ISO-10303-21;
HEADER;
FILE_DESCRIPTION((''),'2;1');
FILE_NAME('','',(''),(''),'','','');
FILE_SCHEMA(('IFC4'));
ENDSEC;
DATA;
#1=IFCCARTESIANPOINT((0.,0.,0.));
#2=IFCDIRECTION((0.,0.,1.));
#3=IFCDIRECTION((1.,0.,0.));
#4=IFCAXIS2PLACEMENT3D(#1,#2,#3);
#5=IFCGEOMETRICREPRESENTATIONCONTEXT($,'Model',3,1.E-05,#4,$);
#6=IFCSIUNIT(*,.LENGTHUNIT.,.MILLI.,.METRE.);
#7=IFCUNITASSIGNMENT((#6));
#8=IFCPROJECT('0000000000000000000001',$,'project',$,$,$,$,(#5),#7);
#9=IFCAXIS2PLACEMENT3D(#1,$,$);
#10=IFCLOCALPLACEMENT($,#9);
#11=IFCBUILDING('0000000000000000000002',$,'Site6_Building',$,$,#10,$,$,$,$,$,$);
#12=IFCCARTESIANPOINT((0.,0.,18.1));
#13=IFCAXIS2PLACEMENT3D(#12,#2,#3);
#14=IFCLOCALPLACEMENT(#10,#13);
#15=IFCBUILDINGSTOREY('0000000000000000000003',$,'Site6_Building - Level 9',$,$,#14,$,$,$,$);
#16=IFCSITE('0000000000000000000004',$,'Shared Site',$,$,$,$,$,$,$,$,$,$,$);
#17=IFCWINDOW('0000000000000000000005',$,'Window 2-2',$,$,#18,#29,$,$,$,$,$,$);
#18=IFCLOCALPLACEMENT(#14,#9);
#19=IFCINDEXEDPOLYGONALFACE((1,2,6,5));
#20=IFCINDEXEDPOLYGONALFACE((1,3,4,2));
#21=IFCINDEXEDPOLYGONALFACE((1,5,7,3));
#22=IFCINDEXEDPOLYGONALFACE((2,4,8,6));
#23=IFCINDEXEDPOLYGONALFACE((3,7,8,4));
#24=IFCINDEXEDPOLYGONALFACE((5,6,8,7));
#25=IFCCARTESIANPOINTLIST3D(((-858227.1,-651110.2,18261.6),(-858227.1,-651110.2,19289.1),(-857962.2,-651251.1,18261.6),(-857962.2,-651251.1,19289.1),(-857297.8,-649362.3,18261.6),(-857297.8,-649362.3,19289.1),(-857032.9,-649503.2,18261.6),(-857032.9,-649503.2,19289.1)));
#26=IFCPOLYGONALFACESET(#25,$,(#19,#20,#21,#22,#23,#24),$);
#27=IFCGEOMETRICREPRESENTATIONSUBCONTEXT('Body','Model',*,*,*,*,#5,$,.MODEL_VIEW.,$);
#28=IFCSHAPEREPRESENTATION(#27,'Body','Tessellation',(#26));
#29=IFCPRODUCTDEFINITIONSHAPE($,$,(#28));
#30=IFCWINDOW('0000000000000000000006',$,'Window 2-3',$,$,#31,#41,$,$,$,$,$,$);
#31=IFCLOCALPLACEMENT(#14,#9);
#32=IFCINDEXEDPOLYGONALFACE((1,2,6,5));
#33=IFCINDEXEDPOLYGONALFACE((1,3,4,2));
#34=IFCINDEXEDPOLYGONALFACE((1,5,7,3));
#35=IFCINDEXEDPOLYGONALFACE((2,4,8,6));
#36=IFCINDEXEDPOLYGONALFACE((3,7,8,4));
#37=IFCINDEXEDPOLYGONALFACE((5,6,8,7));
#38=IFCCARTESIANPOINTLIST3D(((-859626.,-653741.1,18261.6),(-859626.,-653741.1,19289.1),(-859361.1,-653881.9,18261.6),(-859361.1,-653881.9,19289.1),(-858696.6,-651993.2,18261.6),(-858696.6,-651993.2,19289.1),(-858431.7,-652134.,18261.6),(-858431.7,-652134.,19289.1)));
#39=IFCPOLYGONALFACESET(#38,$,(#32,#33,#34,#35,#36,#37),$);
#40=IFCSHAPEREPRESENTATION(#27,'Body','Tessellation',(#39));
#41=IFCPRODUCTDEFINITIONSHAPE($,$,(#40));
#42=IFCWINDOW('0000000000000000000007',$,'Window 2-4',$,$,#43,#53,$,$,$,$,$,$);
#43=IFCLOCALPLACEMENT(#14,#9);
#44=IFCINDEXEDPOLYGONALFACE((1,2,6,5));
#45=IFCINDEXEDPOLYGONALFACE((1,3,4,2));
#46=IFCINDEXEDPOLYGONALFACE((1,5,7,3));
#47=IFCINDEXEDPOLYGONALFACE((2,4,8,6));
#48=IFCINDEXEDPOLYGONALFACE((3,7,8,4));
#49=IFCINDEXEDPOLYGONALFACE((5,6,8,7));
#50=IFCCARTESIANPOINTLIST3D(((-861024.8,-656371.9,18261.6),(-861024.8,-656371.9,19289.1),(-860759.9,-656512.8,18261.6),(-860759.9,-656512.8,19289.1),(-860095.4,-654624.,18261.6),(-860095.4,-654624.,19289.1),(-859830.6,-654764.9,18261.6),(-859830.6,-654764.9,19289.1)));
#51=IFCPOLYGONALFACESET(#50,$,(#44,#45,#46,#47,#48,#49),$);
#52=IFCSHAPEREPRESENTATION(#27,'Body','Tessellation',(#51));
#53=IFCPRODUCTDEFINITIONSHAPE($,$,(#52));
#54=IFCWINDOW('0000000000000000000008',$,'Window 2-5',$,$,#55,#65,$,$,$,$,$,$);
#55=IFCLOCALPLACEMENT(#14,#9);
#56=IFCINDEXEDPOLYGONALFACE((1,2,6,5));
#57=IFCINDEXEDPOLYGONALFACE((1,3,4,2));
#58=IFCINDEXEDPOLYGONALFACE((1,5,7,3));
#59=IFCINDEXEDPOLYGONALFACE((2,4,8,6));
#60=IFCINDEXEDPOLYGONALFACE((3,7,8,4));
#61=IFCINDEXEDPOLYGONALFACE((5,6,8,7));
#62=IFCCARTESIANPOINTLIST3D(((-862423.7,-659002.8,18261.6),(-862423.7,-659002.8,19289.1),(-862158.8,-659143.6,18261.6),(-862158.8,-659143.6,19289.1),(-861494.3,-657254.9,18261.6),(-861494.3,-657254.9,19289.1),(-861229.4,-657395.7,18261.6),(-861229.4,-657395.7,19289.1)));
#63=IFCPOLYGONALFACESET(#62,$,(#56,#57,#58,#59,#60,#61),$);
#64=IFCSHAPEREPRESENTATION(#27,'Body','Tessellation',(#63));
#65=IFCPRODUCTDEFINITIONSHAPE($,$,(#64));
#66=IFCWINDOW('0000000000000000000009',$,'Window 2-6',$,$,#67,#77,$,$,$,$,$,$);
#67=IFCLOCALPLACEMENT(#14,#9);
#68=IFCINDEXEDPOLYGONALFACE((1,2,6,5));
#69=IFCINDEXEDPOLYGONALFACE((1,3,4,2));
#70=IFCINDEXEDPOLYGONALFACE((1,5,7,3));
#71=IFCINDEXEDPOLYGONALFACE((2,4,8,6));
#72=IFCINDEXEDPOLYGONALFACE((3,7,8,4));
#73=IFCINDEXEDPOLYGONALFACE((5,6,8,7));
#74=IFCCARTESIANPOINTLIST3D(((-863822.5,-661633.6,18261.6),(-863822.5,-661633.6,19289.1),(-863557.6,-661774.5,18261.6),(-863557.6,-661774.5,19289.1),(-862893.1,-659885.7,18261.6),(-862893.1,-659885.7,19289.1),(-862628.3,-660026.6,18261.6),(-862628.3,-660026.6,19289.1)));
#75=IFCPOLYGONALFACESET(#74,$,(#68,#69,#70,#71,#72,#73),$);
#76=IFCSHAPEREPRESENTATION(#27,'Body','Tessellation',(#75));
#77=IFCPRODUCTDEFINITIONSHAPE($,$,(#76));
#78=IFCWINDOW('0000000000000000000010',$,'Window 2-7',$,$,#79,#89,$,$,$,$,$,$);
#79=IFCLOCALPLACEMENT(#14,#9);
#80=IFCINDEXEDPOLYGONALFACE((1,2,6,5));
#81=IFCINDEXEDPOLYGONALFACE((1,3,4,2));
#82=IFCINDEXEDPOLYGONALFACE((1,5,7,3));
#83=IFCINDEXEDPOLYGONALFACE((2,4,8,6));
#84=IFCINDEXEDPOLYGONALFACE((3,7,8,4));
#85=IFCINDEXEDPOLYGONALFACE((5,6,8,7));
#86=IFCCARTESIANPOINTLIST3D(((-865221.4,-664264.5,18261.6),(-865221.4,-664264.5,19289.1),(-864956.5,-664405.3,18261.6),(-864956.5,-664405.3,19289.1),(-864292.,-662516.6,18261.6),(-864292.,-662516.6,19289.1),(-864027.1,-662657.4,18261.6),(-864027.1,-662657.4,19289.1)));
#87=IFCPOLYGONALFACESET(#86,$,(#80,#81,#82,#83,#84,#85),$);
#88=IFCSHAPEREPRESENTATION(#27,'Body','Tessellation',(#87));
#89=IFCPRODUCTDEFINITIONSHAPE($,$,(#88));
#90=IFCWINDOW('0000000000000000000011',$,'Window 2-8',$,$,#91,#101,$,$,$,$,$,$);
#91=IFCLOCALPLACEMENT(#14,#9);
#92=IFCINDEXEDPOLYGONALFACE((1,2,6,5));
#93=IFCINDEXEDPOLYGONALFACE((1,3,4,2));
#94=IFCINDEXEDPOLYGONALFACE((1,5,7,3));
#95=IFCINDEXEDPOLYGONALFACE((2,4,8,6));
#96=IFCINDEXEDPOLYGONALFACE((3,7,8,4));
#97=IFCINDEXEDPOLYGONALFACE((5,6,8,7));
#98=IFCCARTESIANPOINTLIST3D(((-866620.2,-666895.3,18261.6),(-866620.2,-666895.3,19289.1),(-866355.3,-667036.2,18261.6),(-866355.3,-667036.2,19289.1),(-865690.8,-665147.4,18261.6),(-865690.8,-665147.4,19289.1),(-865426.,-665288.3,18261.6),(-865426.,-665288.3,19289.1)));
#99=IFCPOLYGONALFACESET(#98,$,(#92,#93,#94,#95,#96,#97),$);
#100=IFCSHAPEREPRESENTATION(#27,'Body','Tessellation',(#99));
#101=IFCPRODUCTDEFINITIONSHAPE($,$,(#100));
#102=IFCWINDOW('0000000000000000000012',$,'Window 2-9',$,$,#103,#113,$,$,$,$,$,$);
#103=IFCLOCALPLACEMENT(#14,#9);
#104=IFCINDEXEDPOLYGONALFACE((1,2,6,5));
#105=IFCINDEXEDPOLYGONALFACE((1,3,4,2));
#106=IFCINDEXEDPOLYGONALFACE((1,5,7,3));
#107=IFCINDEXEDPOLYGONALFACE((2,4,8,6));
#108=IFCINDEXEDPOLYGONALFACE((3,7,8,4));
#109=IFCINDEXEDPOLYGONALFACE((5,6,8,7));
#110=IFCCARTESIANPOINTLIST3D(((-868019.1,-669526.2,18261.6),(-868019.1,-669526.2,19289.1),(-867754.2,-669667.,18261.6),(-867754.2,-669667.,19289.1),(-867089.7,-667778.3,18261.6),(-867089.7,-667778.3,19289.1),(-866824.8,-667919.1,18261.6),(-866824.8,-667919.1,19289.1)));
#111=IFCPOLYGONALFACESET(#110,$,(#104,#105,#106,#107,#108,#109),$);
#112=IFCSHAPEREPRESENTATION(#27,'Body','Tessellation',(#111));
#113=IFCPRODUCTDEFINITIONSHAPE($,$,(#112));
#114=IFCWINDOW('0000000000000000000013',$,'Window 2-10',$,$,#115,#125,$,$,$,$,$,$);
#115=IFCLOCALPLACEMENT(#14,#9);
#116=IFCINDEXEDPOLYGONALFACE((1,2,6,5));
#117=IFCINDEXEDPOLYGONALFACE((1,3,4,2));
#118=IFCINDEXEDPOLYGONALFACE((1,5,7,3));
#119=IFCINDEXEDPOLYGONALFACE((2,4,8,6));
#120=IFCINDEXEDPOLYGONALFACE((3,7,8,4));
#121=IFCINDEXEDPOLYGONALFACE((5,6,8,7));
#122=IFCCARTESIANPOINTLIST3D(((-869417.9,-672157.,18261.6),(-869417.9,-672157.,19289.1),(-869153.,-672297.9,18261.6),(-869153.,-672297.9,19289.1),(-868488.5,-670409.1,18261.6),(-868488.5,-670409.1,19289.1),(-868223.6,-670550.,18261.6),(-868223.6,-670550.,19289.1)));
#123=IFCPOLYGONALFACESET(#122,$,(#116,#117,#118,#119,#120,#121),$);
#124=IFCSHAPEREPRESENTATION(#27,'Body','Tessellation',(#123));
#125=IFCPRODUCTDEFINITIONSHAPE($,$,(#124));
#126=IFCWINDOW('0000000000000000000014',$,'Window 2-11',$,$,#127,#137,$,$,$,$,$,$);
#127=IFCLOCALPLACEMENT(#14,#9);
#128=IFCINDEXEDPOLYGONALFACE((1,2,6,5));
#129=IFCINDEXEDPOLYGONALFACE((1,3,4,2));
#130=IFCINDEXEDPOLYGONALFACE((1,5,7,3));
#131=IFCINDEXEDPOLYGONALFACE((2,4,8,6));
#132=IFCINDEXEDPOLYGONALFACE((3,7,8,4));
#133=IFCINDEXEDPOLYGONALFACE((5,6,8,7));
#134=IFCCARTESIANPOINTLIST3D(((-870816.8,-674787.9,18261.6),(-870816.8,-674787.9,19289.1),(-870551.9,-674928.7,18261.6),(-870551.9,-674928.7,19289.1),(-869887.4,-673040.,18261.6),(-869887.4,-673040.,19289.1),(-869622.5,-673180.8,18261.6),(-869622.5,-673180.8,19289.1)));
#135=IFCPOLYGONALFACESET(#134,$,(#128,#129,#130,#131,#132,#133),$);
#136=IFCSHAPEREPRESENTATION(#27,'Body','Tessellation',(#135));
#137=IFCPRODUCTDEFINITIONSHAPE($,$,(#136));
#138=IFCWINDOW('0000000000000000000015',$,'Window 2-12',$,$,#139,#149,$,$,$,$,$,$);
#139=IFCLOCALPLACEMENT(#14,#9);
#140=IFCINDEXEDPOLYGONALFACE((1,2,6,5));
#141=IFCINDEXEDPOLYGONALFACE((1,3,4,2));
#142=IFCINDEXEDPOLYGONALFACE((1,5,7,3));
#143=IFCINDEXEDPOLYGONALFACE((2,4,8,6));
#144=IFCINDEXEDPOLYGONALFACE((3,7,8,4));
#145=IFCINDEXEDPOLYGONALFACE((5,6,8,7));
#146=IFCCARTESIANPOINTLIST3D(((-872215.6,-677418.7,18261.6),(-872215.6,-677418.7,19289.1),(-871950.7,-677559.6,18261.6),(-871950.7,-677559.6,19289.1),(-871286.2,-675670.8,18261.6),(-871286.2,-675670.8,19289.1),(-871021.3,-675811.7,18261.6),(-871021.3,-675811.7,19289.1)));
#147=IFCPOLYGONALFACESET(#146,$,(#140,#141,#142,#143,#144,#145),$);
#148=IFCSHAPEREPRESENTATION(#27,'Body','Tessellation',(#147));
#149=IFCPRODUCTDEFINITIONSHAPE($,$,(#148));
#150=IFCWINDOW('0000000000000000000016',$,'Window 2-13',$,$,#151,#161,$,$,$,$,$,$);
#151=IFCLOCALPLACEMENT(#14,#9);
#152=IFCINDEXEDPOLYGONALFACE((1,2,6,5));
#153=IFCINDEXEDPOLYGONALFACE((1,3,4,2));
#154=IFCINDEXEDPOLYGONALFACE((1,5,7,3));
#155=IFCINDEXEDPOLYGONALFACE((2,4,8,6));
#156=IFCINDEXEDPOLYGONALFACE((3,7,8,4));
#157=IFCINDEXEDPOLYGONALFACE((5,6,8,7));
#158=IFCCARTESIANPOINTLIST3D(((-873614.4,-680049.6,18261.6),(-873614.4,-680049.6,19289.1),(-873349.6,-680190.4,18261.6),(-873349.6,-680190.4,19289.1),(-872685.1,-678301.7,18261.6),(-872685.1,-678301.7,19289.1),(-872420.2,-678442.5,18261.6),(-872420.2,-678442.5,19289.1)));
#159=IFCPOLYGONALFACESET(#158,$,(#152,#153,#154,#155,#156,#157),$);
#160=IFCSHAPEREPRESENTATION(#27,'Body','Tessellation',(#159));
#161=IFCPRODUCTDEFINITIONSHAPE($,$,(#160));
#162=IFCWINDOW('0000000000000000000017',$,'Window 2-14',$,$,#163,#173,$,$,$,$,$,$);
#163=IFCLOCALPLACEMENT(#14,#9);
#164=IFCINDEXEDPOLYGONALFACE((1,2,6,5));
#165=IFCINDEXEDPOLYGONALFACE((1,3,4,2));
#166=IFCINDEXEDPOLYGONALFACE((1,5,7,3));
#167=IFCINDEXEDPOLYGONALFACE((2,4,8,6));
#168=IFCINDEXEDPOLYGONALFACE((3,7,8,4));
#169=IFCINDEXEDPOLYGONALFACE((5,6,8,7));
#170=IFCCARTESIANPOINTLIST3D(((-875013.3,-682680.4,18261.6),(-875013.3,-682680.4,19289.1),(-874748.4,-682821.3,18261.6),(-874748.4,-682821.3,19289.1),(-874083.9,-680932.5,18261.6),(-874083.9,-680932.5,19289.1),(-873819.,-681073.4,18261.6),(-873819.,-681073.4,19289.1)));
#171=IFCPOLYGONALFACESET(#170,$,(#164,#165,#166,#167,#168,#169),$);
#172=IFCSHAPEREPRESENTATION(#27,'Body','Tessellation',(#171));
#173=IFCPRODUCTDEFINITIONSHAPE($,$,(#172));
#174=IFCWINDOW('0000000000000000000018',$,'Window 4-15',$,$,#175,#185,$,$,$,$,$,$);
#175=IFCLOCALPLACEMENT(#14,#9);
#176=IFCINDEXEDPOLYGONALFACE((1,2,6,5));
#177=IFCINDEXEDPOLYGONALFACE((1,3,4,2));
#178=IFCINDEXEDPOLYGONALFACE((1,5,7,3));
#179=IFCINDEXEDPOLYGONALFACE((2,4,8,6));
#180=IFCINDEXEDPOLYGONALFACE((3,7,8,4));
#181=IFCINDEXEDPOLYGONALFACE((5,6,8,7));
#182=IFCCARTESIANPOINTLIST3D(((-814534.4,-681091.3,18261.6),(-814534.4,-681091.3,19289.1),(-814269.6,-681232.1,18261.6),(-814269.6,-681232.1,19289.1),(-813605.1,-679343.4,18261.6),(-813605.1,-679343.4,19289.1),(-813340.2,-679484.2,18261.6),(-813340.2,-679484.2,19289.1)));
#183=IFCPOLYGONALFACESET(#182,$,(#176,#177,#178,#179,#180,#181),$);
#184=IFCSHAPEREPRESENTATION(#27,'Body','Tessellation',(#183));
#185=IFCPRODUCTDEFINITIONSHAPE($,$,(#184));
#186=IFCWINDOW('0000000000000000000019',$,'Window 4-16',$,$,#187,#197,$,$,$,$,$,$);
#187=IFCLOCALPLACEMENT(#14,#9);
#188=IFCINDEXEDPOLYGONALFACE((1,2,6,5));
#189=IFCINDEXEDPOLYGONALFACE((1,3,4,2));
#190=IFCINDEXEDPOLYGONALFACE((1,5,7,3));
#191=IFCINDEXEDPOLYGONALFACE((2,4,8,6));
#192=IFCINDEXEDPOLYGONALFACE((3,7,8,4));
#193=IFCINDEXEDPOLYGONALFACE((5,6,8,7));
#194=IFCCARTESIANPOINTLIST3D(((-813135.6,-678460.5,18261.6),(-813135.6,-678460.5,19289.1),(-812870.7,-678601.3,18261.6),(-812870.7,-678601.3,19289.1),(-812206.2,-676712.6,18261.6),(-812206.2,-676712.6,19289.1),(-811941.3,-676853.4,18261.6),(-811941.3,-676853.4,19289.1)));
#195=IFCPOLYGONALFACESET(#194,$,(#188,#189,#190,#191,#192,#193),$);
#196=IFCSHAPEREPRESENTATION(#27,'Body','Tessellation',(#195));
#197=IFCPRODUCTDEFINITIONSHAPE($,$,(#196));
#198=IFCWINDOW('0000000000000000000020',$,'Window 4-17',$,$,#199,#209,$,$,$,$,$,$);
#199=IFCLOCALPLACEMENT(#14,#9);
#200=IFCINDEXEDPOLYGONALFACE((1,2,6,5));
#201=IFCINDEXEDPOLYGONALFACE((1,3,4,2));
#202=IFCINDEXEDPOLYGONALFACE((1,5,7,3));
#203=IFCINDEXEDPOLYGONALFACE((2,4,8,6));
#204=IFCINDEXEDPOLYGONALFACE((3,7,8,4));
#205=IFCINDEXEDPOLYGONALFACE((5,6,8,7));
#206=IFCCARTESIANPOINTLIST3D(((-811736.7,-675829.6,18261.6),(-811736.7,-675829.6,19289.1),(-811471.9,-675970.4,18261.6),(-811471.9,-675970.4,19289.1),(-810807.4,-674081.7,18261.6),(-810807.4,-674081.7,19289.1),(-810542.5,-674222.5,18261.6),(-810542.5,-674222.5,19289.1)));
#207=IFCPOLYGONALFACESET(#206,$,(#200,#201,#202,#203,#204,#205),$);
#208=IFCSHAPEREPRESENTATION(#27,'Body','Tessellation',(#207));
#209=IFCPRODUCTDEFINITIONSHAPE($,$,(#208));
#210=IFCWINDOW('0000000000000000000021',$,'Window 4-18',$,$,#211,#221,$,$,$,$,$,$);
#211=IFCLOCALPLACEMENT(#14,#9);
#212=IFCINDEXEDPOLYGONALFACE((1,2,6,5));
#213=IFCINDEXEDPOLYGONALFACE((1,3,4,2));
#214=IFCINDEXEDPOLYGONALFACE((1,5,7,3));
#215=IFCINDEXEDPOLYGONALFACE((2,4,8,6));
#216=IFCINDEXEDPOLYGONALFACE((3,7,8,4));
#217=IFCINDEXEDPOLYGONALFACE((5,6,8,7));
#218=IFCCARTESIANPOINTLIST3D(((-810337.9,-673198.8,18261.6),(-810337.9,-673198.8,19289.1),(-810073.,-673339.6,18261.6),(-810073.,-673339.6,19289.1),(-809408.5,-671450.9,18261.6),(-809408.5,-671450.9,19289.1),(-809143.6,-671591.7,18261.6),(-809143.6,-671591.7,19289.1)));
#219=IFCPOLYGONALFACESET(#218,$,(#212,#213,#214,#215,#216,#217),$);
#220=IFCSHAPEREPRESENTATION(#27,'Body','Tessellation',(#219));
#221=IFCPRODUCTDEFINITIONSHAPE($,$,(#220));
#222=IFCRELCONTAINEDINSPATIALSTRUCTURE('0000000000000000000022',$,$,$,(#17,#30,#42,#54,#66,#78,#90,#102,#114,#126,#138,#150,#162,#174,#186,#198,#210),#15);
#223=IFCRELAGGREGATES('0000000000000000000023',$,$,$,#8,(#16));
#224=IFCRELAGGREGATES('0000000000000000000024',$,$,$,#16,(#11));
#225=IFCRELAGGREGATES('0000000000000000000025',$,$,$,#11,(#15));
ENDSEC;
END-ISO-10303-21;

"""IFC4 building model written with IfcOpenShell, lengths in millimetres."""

from ifc_helpers import new_model, si_unit, frame, origin, origin_with_axes, place, context, subcontext, project, spatial, indexed_curve, outline, extrude, element, save


model = new_model("IFC4")

# Units and contexts
model_context = context("Model", 3, precision=1e-05, world=origin_with_axes())
body_context = subcontext(model_context, "Body", "Model", "MODEL_VIEW")
ifc_project = project(units=[si_unit("LENGTHUNIT", "METRE", prefix="MILLI")], contexts=[model_context])

# Site, building, storey
site = spatial("IfcSite", under=ifc_project, Name="Shared Site")
building_placement = place(None, origin())
building = spatial("IfcBuilding", under=site, at=building_placement, Name="Site6_Building")
storey_placement = place(building_placement, frame((0.0, 0.0, 18.1), z_axis=(0.0, 0.0, 1.0), x_axis=(1.0, 0.0, 0.0)))
storey = spatial("IfcBuildingStorey", under=building, at=storey_placement, Name="Site6_Building - Level 9")

# Windows
for number, where, z_axis, x_axis, name in (
    (1, (-857297.8, -649362.3, 18261.6), (0.0, 0.0, 1.0), (-0.469472, -0.882948, 0.0), "Window 2-2"),
    (2, (-858696.6, -651993.2, 18261.6), (0.0, 0.0, 1.0), (-0.469472, -0.882948, 0.0), "Window 2-3"),
    (3, (-860095.4, -654624.0, 18261.6), (0.0, 0.0, 1.0), (-0.469472, -0.882948, 0.0), "Window 2-4"),
    (4, (-861494.3, -657254.9, 18261.6), (0.0, 0.0, 1.0), (-0.469472, -0.882948, 0.0), "Window 2-5"),
    (5, (-862893.1, -659885.7, 18261.6), (0.0, 0.0, 1.0), (-0.469472, -0.882948, 0.0), "Window 2-6"),
    (6, (-864292.0, -662516.6, 18261.6), (0.0, 0.0, 1.0), (-0.469472, -0.882948, 0.0), "Window 2-7"),
    (7, (-865690.8, -665147.4, 18261.6), (0.0, 0.0, 1.0), (-0.469472, -0.882948, 0.0), "Window 2-8"),
    (8, (-867089.7, -667778.3, 18261.6), (0.0, 0.0, 1.0), (-0.469472, -0.882948, 0.0), "Window 2-9"),
    (9, (-868488.5, -670409.1, 18261.6), (0.0, 0.0, 1.0), (-0.469472, -0.882948, 0.0), "Window 2-10"),
    (10, (-869887.4, -673040.0, 18261.6), (0.0, 0.0, 1.0), (-0.469472, -0.882948, 0.0), "Window 2-11"),
    (11, (-871286.2, -675670.8, 18261.6), (0.0, 0.0, 1.0), (-0.469472, -0.882948, 0.0), "Window 2-12"),
    (12, (-872685.1, -678301.7, 18261.6), (0.0, 0.0, 1.0), (-0.469472, -0.882948, 0.0), "Window 2-13"),
    (13, (-874083.9, -680932.5, 18261.6), (0.0, 0.0, 1.0), (-0.469472, -0.882948, 0.0), "Window 2-14"),
    (14, (-814269.6, -681232.1, 18261.6), (0.0, 0.0, 1.0), (0.469472, 0.882948, 0.0), "Window 4-15"),
    (15, (-812870.7, -678601.3, 18261.6), (0.0, 0.0, 1.0), (0.469472, 0.882948, 0.0), "Window 4-16"),
    (16, (-811471.9, -675970.4, 18261.6), (0.0, 0.0, 1.0), (0.469472, 0.882948, 0.0), "Window 4-17"),
    (17, (-810073.0, -673339.6, 18261.6), (0.0, 0.0, 1.0), (0.469472, 0.882948, 0.0), "Window 4-18"),
):
    element("IfcWindow", number, at=place(storey_placement, frame(where, z_axis=z_axis, x_axis=x_axis)), inside=storey, Name=name, context=body_context, shape_type="SweptSolid", body=[
        extrude(outline(indexed_curve([(0.0, 0.0), (0.0, 300.0), (1979.6, 300.0), (1979.6, 0.0), (0.0, 0.0)], self_intersect=False)), origin_with_axes(), (0.0, 0.0, 1.0), 1027.5),
    ])

save(model, "model.ifc")
